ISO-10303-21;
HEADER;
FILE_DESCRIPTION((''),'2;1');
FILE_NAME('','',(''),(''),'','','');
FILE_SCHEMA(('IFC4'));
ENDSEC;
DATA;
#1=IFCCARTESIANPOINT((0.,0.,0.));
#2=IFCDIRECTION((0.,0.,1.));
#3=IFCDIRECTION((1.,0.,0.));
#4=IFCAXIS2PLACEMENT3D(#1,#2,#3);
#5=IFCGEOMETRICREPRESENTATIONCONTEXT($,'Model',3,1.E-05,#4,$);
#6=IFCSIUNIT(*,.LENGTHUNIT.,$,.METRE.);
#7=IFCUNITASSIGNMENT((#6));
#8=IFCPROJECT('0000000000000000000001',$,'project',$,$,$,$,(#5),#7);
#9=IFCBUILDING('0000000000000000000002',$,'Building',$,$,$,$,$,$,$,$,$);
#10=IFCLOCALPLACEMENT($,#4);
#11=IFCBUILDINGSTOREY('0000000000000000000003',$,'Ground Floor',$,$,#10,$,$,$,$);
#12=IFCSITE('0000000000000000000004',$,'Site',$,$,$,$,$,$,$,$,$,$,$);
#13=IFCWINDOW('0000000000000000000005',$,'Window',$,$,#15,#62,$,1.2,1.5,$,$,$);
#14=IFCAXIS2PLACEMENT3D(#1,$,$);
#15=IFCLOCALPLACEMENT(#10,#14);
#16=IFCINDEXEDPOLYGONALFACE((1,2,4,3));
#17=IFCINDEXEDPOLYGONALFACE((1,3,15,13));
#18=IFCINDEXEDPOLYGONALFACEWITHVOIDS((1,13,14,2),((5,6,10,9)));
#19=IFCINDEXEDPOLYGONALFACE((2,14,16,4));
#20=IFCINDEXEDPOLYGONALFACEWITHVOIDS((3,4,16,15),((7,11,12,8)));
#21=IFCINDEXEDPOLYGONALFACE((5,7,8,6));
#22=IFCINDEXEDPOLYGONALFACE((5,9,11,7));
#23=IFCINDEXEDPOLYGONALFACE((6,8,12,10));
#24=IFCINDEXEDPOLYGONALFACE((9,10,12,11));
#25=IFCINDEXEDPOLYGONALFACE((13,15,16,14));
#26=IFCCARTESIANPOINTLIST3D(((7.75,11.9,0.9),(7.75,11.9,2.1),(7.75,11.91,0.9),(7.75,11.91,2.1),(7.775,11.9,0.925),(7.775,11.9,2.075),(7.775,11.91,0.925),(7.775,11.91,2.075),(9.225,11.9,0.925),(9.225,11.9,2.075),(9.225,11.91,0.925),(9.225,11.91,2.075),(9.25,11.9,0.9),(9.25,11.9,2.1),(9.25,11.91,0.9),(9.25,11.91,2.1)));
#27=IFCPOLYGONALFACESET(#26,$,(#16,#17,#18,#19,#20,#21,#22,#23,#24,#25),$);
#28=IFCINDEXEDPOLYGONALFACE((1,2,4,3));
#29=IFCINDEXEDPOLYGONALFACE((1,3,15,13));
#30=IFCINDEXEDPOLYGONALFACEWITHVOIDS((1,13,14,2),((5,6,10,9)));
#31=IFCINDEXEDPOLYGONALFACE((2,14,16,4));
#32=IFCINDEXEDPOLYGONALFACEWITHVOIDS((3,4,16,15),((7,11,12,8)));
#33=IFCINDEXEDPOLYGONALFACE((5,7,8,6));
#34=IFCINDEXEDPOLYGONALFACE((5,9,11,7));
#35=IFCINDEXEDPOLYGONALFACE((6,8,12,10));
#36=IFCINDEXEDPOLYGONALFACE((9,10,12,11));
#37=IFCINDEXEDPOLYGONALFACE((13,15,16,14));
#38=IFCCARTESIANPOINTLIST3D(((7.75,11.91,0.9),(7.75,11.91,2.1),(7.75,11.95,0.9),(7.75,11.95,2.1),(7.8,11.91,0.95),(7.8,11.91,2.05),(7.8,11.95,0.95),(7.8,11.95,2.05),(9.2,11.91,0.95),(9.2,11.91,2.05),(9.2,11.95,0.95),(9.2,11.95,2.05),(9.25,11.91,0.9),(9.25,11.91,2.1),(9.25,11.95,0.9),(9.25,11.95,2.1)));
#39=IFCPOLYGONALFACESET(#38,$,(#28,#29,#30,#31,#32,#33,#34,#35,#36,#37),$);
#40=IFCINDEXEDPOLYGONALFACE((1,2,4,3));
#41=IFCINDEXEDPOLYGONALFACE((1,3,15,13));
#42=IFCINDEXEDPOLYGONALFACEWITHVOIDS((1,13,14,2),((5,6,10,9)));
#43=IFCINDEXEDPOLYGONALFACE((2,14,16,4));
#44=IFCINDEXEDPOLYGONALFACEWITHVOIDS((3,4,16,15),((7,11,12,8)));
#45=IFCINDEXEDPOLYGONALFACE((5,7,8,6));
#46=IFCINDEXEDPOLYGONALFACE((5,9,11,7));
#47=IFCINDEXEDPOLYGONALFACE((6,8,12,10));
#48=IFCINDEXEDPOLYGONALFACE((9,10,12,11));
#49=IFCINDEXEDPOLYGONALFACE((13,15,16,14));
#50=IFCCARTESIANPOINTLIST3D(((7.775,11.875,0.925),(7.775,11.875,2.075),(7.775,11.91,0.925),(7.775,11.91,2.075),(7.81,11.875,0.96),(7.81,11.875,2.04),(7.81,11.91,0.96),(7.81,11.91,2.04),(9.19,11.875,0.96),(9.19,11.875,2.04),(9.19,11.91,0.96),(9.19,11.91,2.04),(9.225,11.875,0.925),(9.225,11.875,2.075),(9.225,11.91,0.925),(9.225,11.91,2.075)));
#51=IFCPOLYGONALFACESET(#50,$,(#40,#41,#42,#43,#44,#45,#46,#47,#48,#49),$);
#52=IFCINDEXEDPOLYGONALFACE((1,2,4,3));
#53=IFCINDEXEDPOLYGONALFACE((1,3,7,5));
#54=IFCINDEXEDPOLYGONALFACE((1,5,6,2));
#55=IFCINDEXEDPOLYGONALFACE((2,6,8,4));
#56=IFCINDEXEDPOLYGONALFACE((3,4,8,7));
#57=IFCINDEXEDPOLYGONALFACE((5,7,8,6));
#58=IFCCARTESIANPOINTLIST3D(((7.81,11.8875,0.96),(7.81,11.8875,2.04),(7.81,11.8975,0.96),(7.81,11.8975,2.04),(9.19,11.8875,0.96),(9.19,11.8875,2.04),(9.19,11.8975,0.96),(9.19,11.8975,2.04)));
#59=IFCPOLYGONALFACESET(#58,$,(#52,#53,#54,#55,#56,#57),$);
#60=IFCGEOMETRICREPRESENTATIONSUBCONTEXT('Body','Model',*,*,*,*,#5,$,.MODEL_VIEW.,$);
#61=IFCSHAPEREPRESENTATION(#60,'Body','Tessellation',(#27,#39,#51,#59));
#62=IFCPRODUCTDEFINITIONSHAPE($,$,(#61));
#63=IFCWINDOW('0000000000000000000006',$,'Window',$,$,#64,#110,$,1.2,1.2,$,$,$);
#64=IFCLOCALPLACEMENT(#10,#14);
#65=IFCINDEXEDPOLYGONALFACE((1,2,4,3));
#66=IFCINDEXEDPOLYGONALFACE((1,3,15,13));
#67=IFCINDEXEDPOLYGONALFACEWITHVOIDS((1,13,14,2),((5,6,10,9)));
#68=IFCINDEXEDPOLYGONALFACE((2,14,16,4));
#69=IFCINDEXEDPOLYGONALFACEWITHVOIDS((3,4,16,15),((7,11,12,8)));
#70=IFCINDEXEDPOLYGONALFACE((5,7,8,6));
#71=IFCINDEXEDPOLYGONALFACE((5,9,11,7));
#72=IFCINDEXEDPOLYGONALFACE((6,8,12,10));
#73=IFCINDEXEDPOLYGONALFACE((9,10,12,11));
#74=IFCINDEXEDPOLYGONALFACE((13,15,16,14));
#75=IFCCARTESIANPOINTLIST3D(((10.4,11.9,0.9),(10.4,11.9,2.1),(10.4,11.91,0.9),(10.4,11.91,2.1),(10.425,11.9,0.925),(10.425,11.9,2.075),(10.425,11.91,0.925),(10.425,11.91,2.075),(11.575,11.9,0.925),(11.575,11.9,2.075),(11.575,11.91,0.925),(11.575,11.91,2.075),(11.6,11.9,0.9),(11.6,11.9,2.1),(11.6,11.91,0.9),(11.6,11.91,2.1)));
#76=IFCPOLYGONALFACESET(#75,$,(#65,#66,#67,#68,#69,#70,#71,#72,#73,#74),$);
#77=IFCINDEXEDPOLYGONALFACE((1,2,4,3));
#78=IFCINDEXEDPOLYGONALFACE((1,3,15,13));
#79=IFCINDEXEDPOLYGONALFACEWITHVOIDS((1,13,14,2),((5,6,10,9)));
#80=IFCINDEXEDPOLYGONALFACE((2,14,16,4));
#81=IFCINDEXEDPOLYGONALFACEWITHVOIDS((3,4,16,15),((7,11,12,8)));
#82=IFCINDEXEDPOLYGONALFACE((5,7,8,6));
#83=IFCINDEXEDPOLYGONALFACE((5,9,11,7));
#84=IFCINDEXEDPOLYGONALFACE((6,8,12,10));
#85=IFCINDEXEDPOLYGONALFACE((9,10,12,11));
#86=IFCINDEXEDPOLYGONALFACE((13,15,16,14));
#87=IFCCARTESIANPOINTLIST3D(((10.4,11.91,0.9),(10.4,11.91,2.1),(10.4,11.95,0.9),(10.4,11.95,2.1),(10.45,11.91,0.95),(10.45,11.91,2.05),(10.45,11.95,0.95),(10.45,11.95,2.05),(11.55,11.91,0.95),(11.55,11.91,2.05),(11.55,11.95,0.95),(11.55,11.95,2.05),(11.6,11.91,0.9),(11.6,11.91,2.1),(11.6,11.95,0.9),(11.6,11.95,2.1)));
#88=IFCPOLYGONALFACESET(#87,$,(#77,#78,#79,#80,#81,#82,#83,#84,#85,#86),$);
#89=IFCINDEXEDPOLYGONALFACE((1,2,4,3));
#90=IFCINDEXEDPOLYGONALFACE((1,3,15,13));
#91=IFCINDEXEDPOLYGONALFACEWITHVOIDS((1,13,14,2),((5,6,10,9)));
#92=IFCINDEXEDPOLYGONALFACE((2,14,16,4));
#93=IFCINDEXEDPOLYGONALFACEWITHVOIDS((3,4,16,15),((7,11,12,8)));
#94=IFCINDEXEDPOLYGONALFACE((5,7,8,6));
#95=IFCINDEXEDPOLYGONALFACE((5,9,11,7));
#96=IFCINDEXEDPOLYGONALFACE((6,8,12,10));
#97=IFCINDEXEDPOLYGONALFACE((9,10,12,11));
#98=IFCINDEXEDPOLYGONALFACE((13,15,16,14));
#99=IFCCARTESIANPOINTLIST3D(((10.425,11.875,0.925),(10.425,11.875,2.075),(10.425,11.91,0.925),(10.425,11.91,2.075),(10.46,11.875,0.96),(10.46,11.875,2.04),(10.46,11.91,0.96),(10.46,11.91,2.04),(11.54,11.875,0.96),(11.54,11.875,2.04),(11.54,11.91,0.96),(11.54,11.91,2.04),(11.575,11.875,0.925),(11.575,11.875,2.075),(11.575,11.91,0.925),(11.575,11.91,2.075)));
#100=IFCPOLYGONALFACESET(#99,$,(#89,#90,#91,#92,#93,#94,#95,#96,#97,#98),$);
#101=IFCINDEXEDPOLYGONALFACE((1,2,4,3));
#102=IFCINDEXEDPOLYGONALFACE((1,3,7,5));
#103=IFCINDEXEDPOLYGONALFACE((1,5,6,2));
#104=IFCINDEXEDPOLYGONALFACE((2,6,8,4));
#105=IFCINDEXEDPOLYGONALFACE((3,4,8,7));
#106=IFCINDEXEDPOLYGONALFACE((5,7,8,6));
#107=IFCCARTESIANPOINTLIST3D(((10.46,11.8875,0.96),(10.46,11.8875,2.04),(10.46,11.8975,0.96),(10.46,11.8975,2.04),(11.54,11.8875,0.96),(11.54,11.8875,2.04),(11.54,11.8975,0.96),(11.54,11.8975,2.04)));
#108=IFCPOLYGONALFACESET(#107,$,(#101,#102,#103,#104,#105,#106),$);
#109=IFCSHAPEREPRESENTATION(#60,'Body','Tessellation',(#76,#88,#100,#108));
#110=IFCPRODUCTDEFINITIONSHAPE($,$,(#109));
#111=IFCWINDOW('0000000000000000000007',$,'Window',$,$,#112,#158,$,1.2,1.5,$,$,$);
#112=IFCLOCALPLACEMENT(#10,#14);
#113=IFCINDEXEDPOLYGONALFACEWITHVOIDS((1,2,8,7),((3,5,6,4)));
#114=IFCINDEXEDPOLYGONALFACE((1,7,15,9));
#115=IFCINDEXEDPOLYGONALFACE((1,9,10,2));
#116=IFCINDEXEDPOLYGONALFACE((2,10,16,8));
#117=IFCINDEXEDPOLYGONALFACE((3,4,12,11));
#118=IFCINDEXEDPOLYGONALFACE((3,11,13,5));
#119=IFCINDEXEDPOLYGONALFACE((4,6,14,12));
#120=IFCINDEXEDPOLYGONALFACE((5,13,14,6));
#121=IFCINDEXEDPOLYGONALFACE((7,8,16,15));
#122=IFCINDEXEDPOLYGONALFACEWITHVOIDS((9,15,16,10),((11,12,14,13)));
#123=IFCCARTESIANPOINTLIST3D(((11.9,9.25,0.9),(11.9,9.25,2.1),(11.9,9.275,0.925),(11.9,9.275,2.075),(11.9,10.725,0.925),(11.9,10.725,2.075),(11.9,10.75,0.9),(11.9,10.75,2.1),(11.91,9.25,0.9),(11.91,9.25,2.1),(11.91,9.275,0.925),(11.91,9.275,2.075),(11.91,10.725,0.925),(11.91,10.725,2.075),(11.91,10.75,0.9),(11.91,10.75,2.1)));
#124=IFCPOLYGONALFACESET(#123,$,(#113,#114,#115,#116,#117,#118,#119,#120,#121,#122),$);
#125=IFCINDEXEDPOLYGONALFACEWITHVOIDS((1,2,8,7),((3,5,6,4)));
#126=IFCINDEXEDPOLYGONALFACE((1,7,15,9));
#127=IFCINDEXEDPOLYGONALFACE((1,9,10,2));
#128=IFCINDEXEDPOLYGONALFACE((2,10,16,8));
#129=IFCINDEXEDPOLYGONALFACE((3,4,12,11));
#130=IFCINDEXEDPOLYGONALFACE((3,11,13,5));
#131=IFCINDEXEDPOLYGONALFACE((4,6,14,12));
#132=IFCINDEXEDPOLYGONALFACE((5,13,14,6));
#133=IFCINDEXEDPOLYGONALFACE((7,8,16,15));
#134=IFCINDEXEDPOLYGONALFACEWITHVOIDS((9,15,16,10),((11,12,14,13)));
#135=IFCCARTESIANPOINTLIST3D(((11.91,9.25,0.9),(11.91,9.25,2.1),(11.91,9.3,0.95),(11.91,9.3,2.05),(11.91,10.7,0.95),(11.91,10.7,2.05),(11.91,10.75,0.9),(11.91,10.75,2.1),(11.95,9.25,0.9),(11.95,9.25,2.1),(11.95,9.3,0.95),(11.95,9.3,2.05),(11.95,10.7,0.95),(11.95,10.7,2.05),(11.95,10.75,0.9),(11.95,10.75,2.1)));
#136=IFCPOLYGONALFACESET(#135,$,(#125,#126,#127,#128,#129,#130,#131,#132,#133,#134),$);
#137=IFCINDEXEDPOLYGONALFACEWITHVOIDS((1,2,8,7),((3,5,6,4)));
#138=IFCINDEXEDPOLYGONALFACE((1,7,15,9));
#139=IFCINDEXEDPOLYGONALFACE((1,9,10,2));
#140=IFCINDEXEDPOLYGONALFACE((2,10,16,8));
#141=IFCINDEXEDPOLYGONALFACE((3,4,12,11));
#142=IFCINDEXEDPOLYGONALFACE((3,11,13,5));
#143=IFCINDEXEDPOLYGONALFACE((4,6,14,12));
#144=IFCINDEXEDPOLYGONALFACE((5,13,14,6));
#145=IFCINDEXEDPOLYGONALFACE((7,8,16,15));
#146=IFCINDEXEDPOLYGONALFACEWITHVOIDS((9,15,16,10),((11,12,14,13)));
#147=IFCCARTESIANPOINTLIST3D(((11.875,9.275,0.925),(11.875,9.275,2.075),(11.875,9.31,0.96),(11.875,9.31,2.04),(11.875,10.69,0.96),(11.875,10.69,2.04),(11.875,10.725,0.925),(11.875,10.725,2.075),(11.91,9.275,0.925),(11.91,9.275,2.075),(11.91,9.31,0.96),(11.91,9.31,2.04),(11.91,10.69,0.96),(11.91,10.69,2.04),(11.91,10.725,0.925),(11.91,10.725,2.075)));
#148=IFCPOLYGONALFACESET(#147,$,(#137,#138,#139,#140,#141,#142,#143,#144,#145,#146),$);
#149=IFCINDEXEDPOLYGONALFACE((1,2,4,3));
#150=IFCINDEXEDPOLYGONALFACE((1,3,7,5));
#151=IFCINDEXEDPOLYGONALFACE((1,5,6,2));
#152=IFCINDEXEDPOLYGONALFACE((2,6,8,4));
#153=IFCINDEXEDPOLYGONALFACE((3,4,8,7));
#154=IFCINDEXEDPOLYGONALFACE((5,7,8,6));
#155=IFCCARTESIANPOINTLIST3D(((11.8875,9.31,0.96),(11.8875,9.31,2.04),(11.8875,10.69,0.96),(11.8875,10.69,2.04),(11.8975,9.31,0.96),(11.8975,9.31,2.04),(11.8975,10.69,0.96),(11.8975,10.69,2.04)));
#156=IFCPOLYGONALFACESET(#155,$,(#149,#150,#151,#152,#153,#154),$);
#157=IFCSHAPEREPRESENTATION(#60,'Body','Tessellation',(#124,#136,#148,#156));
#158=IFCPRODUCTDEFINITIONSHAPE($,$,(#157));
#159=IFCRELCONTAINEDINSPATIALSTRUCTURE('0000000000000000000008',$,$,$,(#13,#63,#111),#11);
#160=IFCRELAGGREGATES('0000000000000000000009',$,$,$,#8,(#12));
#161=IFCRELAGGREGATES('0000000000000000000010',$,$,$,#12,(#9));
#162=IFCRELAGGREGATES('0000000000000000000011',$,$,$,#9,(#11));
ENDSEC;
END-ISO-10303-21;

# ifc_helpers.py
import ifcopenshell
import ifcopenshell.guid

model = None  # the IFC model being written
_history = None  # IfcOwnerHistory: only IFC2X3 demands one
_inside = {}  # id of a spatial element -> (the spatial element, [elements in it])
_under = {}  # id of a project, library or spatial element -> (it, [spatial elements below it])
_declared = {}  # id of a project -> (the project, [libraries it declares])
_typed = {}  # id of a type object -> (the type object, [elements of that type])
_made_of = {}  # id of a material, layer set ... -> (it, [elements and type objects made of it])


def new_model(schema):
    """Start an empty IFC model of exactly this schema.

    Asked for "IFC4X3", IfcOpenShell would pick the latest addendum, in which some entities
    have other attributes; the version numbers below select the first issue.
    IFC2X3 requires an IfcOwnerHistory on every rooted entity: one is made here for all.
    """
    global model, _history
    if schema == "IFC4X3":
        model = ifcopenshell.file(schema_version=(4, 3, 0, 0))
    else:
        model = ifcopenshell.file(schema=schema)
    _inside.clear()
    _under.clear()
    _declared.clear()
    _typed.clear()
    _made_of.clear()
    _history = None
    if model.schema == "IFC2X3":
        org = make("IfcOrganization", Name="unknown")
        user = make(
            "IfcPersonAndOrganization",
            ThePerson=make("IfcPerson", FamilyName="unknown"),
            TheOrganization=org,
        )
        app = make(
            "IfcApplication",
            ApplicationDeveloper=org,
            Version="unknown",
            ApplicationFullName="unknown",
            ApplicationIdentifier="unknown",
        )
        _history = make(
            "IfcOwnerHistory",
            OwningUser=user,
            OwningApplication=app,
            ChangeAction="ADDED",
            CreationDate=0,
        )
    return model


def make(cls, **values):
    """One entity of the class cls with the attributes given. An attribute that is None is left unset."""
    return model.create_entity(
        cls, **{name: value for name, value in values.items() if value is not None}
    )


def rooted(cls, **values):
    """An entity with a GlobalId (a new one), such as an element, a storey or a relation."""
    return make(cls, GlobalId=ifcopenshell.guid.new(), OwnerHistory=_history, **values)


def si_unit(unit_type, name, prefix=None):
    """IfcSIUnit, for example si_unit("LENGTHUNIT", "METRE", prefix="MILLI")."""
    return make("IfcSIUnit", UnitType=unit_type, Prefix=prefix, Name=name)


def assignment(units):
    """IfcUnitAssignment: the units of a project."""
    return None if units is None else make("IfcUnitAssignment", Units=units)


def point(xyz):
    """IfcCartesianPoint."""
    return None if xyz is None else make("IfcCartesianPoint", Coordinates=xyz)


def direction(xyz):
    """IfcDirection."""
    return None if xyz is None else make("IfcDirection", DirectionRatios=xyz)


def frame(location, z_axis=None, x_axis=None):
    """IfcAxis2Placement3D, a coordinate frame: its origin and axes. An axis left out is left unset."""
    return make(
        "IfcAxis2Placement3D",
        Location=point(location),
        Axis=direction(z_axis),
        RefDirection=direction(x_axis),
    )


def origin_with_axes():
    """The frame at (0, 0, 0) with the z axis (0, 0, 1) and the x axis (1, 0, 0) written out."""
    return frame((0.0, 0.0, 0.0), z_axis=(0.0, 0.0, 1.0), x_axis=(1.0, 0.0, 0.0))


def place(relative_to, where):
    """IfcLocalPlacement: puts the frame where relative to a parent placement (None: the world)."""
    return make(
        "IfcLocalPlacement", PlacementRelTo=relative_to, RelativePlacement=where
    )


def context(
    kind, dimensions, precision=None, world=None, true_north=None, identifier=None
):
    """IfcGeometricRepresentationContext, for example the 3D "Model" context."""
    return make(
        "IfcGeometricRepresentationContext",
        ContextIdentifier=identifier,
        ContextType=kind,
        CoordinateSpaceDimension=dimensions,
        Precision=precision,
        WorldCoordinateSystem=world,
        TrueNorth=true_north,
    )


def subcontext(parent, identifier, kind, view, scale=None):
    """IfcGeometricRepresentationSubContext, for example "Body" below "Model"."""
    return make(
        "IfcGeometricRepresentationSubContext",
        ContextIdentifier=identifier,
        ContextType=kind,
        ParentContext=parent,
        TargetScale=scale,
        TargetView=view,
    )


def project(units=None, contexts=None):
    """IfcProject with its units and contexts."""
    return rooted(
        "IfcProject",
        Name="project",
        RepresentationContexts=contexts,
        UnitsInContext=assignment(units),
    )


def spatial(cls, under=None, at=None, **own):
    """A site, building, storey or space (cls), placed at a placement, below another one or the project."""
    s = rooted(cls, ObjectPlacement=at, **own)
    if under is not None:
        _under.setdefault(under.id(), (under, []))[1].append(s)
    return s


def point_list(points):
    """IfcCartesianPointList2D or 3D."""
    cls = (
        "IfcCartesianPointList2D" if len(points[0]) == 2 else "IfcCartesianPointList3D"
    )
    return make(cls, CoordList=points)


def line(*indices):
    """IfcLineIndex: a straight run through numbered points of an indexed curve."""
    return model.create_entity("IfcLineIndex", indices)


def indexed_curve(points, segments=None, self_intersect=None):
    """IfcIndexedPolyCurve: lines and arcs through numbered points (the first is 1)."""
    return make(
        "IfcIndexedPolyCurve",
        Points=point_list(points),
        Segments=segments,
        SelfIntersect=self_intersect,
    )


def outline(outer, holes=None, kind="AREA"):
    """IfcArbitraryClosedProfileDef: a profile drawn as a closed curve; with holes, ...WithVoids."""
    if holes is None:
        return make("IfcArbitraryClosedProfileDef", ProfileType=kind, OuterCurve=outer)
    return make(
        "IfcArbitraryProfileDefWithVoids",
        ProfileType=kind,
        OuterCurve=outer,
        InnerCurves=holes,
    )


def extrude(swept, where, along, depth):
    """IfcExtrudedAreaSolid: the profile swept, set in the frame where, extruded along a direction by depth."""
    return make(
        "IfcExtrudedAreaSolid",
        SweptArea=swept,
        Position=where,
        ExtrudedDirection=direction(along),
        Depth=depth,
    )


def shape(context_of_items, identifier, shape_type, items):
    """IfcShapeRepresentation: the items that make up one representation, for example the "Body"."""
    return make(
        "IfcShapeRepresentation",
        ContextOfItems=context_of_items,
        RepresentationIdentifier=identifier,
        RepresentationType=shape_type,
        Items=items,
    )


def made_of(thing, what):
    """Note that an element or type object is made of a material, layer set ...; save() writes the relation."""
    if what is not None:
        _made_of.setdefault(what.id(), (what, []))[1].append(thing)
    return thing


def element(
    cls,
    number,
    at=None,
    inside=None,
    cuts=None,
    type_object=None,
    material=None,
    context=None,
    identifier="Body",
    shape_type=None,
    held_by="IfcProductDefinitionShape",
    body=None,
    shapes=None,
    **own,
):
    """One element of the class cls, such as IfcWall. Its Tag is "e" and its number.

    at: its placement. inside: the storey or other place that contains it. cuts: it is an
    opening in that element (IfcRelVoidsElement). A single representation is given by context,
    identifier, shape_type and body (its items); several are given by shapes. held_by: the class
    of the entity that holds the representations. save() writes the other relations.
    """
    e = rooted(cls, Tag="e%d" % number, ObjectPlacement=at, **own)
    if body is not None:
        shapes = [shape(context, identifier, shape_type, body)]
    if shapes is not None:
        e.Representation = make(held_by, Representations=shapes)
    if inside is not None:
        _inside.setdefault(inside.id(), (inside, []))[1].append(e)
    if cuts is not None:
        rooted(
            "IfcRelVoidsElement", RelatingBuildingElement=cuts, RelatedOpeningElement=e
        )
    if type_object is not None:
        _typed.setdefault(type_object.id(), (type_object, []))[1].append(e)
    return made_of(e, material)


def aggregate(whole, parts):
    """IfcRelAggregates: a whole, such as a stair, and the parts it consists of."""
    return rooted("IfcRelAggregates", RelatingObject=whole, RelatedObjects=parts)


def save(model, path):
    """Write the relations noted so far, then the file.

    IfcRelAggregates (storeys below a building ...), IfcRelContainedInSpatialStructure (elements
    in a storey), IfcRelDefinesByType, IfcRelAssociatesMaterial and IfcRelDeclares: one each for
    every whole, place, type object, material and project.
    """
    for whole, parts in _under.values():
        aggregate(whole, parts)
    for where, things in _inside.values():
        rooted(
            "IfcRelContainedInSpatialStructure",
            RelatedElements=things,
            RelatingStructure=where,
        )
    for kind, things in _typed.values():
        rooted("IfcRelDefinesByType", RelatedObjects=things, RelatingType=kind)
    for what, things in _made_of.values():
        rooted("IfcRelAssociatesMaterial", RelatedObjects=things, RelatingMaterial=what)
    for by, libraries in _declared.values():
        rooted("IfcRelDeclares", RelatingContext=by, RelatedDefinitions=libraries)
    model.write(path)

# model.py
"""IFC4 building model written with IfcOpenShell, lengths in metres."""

from ifc_helpers import new_model, si_unit, frame, origin_with_axes, place, context, subcontext, project, spatial, line, indexed_curve, outline, extrude, element, save


model = new_model("IFC4")

# Units and contexts
model_context = context("Model", 3, precision=1e-05, world=origin_with_axes())
body_context = subcontext(model_context, "Body", "Model", "MODEL_VIEW")
ifc_project = project(units=[si_unit("LENGTHUNIT", "METRE")], contexts=[model_context])

# Site, building, storey
site = spatial("IfcSite", under=ifc_project, Name="Site")
building = spatial("IfcBuilding", under=site, Name="Building")
storey_placement = place(None, origin_with_axes())
storey = spatial("IfcBuildingStorey", under=building, at=storey_placement, Name="Ground Floor")

# Windows
window_1_placement = place(storey_placement, frame((9.25, 12.0, 0.9), z_axis=(0.0, 0.0, 1.0), x_axis=(-1.0, 0.0, 0.0)))
element("IfcWindow", 1, at=window_1_placement, inside=storey, Name="Window", OverallHeight=1.2, OverallWidth=1.5, context=body_context, shape_type="SweptSolid", body=[
    extrude(outline(indexed_curve([(0.0, 0.0), (1.5, 0.0), (1.5, 1.2), (0.0, 1.2)], segments=[line(1, 2, 3, 4, 1)]), holes=[indexed_curve([(0.025, 0.025), (1.475, 0.025), (1.475, 1.175), (0.025, 1.175)], segments=[line(1, 2, 3, 4, 1)])]), frame((0.0, 0.09, 0.0), z_axis=(0.0, -1.0, 0.0), x_axis=(1.0, 0.0, 0.0)), (0.0, 0.0, -1.0), 0.01),
    extrude(outline(indexed_curve([(0.0, 0.0), (1.5, 0.0), (1.5, 1.2), (0.0, 1.2)], segments=[line(1, 2, 3, 4, 1)]), holes=[indexed_curve([(0.05, 0.05), (1.45, 0.05), (1.45, 1.15), (0.05, 1.15)], segments=[line(1, 2, 3, 4, 1)])]), frame((0.0, 0.05, 0.0), z_axis=(0.0, -1.0, 0.0), x_axis=(1.0, 0.0, 0.0)), (0.0, 0.0, -1.0), 0.04),
    extrude(outline(indexed_curve([(0.0, 0.0), (1.45, 0.0), (1.45, 1.15), (0.0, 1.15)], segments=[line(1, 2, 3, 4, 1)]), holes=[indexed_curve([(0.035, 0.035), (1.415, 0.035), (1.415, 1.115), (0.035, 1.115)], segments=[line(1, 2, 3, 4, 1)])]), frame((0.025, 0.09, 0.025), z_axis=(0.0, -1.0, 0.0), x_axis=(1.0, 0.0, 0.0)), (0.0, 0.0, -1.0), 0.035),
    extrude(outline(indexed_curve([(0.035, 0.035), (1.415, 0.035), (1.415, 1.115), (0.035, 1.115)], segments=[line(1, 2, 3, 4, 1)])), frame((0.025, 0.1025, 0.025), z_axis=(0.0, -1.0, 0.0), x_axis=(1.0, 0.0, 0.0)), (0.0, 0.0, -1.0), 0.01),
])
window_2_placement = place(storey_placement, frame((11.6, 12.0, 0.9), z_axis=(0.0, 0.0, 1.0), x_axis=(-1.0, 0.0, 0.0)))
element("IfcWindow", 2, at=window_2_placement, inside=storey, Name="Window", OverallHeight=1.2, OverallWidth=1.2, context=body_context, shape_type="SweptSolid", body=[
    extrude(outline(indexed_curve([(0.0, 0.0), (1.2, 0.0), (1.2, 1.2), (0.0, 1.2)], segments=[line(1, 2, 3, 4, 1)]), holes=[indexed_curve([(0.025, 0.025), (1.175, 0.025), (1.175, 1.175), (0.025, 1.175)], segments=[line(1, 2, 3, 4, 1)])]), frame((0.0, 0.09, 0.0), z_axis=(0.0, -1.0, 0.0), x_axis=(1.0, 0.0, 0.0)), (0.0, 0.0, -1.0), 0.01),
    extrude(outline(indexed_curve([(0.0, 0.0), (1.2, 0.0), (1.2, 1.2), (0.0, 1.2)], segments=[line(1, 2, 3, 4, 1)]), holes=[indexed_curve([(0.05, 0.05), (1.15, 0.05), (1.15, 1.15), (0.05, 1.15)], segments=[line(1, 2, 3, 4, 1)])]), frame((0.0, 0.05, 0.0), z_axis=(0.0, -1.0, 0.0), x_axis=(1.0, 0.0, 0.0)), (0.0, 0.0, -1.0), 0.04),
    extrude(outline(indexed_curve([(0.0, 0.0), (1.15, 0.0), (1.15, 1.15), (0.0, 1.15)], segments=[line(1, 2, 3, 4, 1)]), holes=[indexed_curve([(0.035, 0.035), (1.115, 0.035), (1.115, 1.115), (0.035, 1.115)], segments=[line(1, 2, 3, 4, 1)])]), frame((0.025, 0.09, 0.025), z_axis=(0.0, -1.0, 0.0), x_axis=(1.0, 0.0, 0.0)), (0.0, 0.0, -1.0), 0.035),
    extrude(outline(indexed_curve([(0.035, 0.035), (1.115, 0.035), (1.115, 1.115), (0.035, 1.115)], segments=[line(1, 2, 3, 4, 1)])), frame((0.025, 0.1025, 0.025), z_axis=(0.0, -1.0, 0.0), x_axis=(1.0, 0.0, 0.0)), (0.0, 0.0, -1.0), 0.01),
])
window_3_placement = place(storey_placement, frame((12.0, 9.25, 0.9), z_axis=(0.0, 0.0, 1.0), x_axis=(0.0, 1.0, 0.0)))
element("IfcWindow", 3, at=window_3_placement, inside=storey, Name="Window", OverallHeight=1.2, OverallWidth=1.5, context=body_context, shape_type="SweptSolid", body=[
    extrude(outline(indexed_curve([(0.0, 0.0), (1.5, 0.0), (1.5, 1.2), (0.0, 1.2)], segments=[line(1, 2, 3, 4, 1)]), holes=[indexed_curve([(0.025, 0.025), (1.475, 0.025), (1.475, 1.175), (0.025, 1.175)], segments=[line(1, 2, 3, 4, 1)])]), frame((0.0, 0.09, 0.0), z_axis=(0.0, -1.0, 0.0), x_axis=(1.0, 0.0, 0.0)), (0.0, 0.0, -1.0), 0.01),
    extrude(outline(indexed_curve([(0.0, 0.0), (1.5, 0.0), (1.5, 1.2), (0.0, 1.2)], segments=[line(1, 2, 3, 4, 1)]), holes=[indexed_curve([(0.05, 0.05), (1.45, 0.05), (1.45, 1.15), (0.05, 1.15)], segments=[line(1, 2, 3, 4, 1)])]), frame((0.0, 0.05, 0.0), z_axis=(0.0, -1.0, 0.0), x_axis=(1.0, 0.0, 0.0)), (0.0, 0.0, -1.0), 0.04),
    extrude(outline(indexed_curve([(0.0, 0.0), (1.45, 0.0), (1.45, 1.15), (0.0, 1.15)], segments=[line(1, 2, 3, 4, 1)]), holes=[indexed_curve([(0.035, 0.035), (1.415, 0.035), (1.415, 1.115), (0.035, 1.115)], segments=[line(1, 2, 3, 4, 1)])]), frame((0.025, 0.09, 0.025), z_axis=(0.0, -1.0, 0.0), x_axis=(1.0, 0.0, 0.0)), (0.0, 0.0, -1.0), 0.035),
    extrude(outline(indexed_curve([(0.035, 0.035), (1.415, 0.035), (1.415, 1.115), (0.035, 1.115)], segments=[line(1, 2, 3, 4, 1)])), frame((0.025, 0.1025, 0.025), z_axis=(0.0, -1.0, 0.0), x_axis=(1.0, 0.0, 0.0)), (0.0, 0.0, -1.0), 0.01),
])

save(model, "model.ifc")
